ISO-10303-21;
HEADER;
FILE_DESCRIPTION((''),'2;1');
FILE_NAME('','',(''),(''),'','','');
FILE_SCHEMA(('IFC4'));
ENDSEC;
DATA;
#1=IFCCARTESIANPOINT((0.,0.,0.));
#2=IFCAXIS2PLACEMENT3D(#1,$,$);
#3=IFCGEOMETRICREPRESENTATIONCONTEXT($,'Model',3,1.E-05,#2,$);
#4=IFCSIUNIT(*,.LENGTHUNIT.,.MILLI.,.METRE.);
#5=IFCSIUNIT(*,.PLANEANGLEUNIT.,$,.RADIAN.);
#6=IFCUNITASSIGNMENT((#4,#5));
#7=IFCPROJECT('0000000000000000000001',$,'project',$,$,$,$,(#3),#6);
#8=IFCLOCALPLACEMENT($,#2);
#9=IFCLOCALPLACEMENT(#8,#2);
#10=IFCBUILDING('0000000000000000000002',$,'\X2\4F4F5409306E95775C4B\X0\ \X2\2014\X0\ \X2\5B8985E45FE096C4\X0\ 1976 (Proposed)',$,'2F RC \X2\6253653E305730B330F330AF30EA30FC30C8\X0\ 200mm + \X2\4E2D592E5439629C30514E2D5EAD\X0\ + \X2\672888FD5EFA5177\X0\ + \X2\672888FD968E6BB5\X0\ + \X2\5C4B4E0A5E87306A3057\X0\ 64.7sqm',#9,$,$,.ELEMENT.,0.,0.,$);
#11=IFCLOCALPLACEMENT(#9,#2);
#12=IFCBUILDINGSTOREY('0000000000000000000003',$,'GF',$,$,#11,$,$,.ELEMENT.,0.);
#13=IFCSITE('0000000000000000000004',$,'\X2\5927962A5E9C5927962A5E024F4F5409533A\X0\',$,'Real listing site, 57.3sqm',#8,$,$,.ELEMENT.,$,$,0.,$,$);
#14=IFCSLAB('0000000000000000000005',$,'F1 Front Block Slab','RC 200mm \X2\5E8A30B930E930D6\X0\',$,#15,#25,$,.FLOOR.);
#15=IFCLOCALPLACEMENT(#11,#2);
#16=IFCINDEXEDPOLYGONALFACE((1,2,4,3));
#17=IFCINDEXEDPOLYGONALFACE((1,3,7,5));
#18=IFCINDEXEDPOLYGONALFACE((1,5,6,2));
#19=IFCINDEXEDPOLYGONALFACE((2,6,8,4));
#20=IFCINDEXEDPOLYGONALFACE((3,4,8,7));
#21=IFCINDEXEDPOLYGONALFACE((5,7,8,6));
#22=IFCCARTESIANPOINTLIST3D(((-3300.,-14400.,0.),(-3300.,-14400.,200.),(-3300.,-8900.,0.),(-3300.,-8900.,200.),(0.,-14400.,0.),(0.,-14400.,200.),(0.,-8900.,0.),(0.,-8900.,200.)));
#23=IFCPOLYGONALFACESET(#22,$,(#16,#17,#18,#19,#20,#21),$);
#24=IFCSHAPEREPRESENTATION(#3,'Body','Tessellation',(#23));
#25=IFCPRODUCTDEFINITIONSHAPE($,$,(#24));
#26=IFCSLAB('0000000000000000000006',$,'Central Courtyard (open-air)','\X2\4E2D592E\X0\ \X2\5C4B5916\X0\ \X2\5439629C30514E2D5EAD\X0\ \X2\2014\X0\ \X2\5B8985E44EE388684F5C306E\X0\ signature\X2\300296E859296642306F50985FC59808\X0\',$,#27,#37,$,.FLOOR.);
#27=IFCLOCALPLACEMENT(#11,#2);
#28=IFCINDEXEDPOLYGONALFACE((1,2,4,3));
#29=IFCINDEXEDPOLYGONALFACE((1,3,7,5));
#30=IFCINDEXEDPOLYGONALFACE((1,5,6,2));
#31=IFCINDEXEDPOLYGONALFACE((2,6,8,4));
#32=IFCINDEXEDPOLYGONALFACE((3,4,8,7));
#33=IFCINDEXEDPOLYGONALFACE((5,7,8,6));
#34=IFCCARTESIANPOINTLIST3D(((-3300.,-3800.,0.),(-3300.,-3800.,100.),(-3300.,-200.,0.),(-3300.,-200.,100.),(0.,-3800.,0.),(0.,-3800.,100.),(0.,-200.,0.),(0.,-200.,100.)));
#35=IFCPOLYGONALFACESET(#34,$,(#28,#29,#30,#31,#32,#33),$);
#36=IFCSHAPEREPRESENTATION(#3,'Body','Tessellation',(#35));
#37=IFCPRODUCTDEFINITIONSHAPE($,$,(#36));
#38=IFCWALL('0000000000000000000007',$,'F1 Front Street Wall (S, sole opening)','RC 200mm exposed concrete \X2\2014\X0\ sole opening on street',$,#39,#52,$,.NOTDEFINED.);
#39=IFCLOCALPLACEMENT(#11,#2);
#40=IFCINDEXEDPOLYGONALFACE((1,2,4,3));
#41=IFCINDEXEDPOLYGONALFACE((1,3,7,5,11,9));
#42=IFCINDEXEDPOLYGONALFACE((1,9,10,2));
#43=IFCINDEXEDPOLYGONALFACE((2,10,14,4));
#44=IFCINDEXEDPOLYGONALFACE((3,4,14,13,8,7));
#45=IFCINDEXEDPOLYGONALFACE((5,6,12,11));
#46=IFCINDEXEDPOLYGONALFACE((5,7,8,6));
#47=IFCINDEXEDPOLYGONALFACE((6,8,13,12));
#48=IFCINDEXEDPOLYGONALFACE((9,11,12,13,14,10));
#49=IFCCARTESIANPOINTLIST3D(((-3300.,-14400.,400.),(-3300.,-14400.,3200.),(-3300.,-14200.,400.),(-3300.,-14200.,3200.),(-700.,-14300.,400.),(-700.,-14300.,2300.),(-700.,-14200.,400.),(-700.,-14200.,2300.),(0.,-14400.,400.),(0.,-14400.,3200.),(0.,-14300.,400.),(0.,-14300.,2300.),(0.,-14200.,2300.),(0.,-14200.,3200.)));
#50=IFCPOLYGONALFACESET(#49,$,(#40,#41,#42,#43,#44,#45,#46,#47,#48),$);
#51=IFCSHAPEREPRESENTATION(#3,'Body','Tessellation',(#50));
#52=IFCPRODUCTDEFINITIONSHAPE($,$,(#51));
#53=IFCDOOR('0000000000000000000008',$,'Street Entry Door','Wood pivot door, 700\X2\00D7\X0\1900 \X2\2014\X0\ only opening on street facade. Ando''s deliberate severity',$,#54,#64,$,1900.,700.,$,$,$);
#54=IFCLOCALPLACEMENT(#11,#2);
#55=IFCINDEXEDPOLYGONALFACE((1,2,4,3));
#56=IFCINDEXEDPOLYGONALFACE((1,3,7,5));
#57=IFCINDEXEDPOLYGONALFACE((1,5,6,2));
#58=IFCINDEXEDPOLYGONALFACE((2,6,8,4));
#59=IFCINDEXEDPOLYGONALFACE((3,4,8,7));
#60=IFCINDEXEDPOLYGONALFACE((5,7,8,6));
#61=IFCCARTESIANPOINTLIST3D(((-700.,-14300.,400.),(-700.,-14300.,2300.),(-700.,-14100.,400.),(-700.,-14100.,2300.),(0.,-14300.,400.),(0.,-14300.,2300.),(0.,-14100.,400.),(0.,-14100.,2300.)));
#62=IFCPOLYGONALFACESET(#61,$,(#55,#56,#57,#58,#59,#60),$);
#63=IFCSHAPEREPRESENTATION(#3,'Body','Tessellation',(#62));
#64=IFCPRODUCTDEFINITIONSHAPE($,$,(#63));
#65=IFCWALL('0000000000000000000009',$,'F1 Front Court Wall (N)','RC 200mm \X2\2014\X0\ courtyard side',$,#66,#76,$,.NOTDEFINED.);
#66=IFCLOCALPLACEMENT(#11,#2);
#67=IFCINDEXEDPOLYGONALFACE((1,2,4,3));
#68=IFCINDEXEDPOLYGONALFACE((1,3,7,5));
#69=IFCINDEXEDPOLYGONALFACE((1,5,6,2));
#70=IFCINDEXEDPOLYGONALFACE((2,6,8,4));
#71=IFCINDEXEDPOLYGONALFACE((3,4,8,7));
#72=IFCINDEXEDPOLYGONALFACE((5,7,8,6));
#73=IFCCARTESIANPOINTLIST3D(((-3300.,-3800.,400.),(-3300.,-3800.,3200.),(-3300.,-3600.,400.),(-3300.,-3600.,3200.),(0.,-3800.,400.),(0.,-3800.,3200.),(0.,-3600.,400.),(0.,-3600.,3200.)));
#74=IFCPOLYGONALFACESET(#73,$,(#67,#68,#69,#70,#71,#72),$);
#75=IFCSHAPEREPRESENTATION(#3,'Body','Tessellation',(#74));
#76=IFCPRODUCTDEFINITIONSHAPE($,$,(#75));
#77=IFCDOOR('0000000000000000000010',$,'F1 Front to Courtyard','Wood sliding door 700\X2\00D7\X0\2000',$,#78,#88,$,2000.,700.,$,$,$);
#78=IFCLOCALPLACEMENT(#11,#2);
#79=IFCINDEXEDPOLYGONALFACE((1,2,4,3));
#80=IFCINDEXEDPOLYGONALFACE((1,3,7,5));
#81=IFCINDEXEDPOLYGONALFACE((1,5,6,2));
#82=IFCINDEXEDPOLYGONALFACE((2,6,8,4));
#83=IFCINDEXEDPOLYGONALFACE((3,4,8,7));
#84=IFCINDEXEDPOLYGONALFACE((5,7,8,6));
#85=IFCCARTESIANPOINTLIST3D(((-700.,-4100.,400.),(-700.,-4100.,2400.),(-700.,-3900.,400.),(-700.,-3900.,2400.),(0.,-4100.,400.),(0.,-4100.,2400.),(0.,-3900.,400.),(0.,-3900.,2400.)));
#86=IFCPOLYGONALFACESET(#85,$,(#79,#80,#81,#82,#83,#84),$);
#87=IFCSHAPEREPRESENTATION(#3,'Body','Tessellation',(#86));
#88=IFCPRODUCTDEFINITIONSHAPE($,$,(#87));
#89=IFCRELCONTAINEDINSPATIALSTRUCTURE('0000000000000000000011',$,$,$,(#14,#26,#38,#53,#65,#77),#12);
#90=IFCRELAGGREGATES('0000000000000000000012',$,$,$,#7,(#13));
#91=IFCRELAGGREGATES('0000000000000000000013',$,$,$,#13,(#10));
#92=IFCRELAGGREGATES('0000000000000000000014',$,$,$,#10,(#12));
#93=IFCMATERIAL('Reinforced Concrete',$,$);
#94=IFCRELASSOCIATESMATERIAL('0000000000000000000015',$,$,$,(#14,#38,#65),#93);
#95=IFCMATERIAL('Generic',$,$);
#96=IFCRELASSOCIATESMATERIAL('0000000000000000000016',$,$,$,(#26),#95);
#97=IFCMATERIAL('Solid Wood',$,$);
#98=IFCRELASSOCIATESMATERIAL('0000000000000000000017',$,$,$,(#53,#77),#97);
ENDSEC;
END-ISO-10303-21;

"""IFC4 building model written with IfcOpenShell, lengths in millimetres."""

from ifc_helpers import new_model, si_unit, frame, frame_2d, origin, place, context, project, spatial, rectangle, extrude, material, element, fill, save


model = new_model("IFC4")

# Units and contexts
model_context = context("Model", 3, precision=1e-05, world=origin())
ifc_project = project(units=[si_unit("LENGTHUNIT", "METRE", prefix="MILLI"), si_unit("PLANEANGLEUNIT", "RADIAN")], contexts=[model_context])

# Site, building, storey
site_placement = place(None, origin())
site = spatial("IfcSite", under=ifc_project, at=site_placement, Name="大阪府大阪市住吉区", ObjectType="Real listing site, 57.3sqm", CompositionType="ELEMENT", RefElevation=0.0)
building_placement = place(site_placement, origin())
building = spatial("IfcBuilding", under=site, at=building_placement, Name="住吉の長屋 — 安藤忠雄 1976 (Proposed)", ObjectType="2F RC 打放しコンクリート 200mm + 中央吹抜け中庭 + 木製建具 + 木製階段 + 屋上庇なし 64.7sqm", CompositionType="ELEMENT", ElevationOfRefHeight=0.0, ElevationOfTerrain=0.0)
storey_placement = place(building_placement, origin())
storey = spatial("IfcBuildingStorey", under=building, at=storey_placement, Name="GF", CompositionType="ELEMENT", Elevation=0.0)

# Slabs
ifc_material_1 = material(Name="Reinforced Concrete")
slab_1_placement = place(storey_placement, frame((-1650.0, -7200.0, 0.0)))
element("IfcSlab", 1, at=slab_1_placement, inside=storey, material=ifc_material_1, Name="F1 Front Block Slab", Description="RC 200mm 床スラブ", PredefinedType="FLOOR", context=model_context, shape_type="SweptSolid", body=[
    extrude(rectangle(XDim=3300.0, YDim=5500.0, at=frame_2d((1650.0, 2750.0))), frame((-1650.0, -7200.0, 0.0)), (0.0, 0.0, 1.0), 200.0),
])
ifc_material_2 = material(Name="Generic")
slab_2_placement = place(storey_placement, frame((-1650.0, -1900.0, 0.0)))
element("IfcSlab", 2, at=slab_2_placement, inside=storey, material=ifc_material_2, Name="Central Courtyard (open-air)", Description="中央 屋外 吹抜け中庭 — 安藤代表作の signature。雨天時は傘必須", PredefinedType="FLOOR", context=model_context, shape_type="SweptSolid", body=[
    extrude(rectangle(XDim=3300.0, YDim=3600.0, at=frame_2d((1650.0, 1800.0))), frame((-1650.0, -1900.0, 0.0)), (0.0, 0.0, 1.0), 100.0),
])

# Wall, opening, door
wall_1_placement = place(storey_placement, frame((-1650.0, -7200.0, 200.0)))
wall_1 = element("IfcWall", 3, at=wall_1_placement, inside=storey, material=ifc_material_1, Name="F1 Front Street Wall (S, sole opening)", Description="RC 200mm exposed concrete — sole opening on street", PredefinedType="NOTDEFINED", context=model_context, shape_type="SweptSolid", body=[
    extrude(rectangle(XDim=3300.0, YDim=200.0, at=frame_2d((1650.0, 100.0))), frame((-1650.0, -7200.0, 200.0)), (0.0, 0.0, 1.0), 2800.0),
])
opening_1_placement = place(storey_placement, frame((-350.0, -7150.0, 200.0)))
opening_1 = element("IfcOpeningElement", 4, at=opening_1_placement, cuts=wall_1, PredefinedType="NOTDEFINED", context=model_context, shape_type="SweptSolid", body=[
    extrude(rectangle(XDim=700.0, YDim=200.0, at=frame_2d((350.0, 100.0))), frame((-350.0, -7150.0, 200.0)), (0.0, 0.0, 1.0), 1900.0),
])
ifc_material_3 = material(Name="Solid Wood")
door_1_placement = place(storey_placement, frame((-350.0, -7150.0, 200.0)))
door_1 = element("IfcDoor", 5, at=door_1_placement, inside=storey, material=ifc_material_3, Name="Street Entry Door", Description="Wood pivot door, 700×1900 — only opening on street facade. Ando's deliberate severity", OverallHeight=1900.0, OverallWidth=700.0, context=model_context, shape_type="SweptSolid", body=[
    extrude(rectangle(XDim=700.0, YDim=200.0, at=frame_2d((350.0, 100.0))), frame((-350.0, -7150.0, 200.0)), (0.0, 0.0, 1.0), 1900.0),
])
fill(opening_1, door_1)

# Wall, opening, door
wall_2_placement = place(storey_placement, frame((-1650.0, -1900.0, 200.0)))
wall_2 = element("IfcWall", 6, at=wall_2_placement, inside=storey, material=ifc_material_1, Name="F1 Front Court Wall (N)", Description="RC 200mm — courtyard side", PredefinedType="NOTDEFINED", context=model_context, shape_type="SweptSolid", body=[
    extrude(rectangle(XDim=3300.0, YDim=200.0, at=frame_2d((1650.0, 100.0))), frame((-1650.0, -1900.0, 200.0)), (0.0, 0.0, 1.0), 2800.0),
])
opening_2_placement = place(storey_placement, frame((-350.0, -2050.0, 200.0)))
opening_2 = element("IfcOpeningElement", 7, at=opening_2_placement, cuts=wall_2, PredefinedType="NOTDEFINED", context=model_context, shape_type="SweptSolid", body=[
    extrude(rectangle(XDim=700.0, YDim=200.0, at=frame_2d((350.0, 100.0))), frame((-350.0, -2050.0, 200.0)), (0.0, 0.0, 1.0), 2000.0),
])
door_2_placement = place(storey_placement, frame((-350.0, -2050.0, 200.0)))
door_2 = element("IfcDoor", 8, at=door_2_placement, inside=storey, material=ifc_material_3, Name="F1 Front to Courtyard", Description="Wood sliding door 700×2000", OverallHeight=2000.0, OverallWidth=700.0, context=model_context, shape_type="SweptSolid", body=[
    extrude(rectangle(XDim=700.0, YDim=200.0, at=frame_2d((350.0, 100.0))), frame((-350.0, -2050.0, 200.0)), (0.0, 0.0, 1.0), 2000.0),
])
fill(opening_2, door_2)

save(model, "model.ifc")
